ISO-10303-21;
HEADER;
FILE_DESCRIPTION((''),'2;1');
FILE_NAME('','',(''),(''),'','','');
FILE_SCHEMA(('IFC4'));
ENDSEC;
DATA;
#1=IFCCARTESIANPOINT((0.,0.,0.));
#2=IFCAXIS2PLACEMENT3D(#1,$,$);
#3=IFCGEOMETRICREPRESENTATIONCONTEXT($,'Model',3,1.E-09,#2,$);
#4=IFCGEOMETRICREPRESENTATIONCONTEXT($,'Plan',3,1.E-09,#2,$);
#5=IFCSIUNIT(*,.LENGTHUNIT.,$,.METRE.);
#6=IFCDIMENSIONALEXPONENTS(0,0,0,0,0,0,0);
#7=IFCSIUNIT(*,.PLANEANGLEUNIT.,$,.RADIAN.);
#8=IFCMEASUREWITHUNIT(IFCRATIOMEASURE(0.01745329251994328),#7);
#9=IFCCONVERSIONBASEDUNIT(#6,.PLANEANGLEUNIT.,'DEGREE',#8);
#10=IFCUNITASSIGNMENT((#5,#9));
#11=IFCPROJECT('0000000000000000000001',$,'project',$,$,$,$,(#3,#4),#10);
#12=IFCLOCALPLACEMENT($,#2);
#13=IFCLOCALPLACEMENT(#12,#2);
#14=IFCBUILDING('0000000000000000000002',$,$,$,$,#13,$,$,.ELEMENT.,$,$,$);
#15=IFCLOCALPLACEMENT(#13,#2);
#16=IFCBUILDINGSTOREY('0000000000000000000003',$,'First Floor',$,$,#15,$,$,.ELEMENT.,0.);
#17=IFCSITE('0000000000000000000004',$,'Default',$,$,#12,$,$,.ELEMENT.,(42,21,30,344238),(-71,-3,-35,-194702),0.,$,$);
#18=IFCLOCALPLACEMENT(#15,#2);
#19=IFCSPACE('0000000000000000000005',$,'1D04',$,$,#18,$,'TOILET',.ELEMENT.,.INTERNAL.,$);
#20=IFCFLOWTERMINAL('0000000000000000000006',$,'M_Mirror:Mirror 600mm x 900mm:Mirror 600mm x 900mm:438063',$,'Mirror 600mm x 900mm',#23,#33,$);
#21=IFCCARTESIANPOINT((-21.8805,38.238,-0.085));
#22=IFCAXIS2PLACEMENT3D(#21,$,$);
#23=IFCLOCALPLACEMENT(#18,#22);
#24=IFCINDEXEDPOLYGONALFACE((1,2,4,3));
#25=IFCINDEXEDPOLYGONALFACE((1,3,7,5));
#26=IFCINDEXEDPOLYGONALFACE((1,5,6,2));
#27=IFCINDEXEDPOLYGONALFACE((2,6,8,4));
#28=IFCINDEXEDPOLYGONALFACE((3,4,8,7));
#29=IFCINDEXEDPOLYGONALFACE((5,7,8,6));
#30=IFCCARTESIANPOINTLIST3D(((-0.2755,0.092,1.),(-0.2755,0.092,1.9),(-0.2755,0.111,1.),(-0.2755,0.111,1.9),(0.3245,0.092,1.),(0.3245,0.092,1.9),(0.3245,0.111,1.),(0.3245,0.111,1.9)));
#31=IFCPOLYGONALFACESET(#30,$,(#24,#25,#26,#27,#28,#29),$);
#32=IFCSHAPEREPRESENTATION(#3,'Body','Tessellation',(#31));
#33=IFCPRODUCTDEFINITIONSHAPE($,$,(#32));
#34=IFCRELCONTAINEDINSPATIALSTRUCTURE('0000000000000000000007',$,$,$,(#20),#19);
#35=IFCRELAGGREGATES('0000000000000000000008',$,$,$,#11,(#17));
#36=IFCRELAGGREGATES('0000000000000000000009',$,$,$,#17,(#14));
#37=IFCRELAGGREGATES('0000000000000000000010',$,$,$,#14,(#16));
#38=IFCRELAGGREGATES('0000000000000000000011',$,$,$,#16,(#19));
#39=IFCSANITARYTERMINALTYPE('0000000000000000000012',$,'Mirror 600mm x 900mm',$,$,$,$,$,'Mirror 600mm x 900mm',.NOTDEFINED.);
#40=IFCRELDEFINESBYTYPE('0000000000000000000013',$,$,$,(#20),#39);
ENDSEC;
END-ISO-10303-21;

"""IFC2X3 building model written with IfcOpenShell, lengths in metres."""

from ifc_helpers import new_model, entity, si_unit, converted_unit, frame, origin, origin_2d_with_axis, place, context, project, spatial, rectangle, extrude, source, transform, mapped, type_object, type_shapes, element, save


model = new_model("IFC2X3")

# Units and contexts
model_context = context("Model", 3, precision=1e-09, world=origin())
plan_context = context("Plan", 3, precision=1e-09, world=origin())
ifc_project = project(units=[si_unit("LENGTHUNIT", "METRE"), converted_unit("PLANEANGLEUNIT", "DEGREE", entity("IfcRatioMeasure", 0.01745329251994328), si_unit("PLANEANGLEUNIT", "RADIAN"), dimensions=[0, 0, 0, 0, 0, 0, 0])], contexts=[model_context, plan_context])

# Site, building, storey
site_placement = place(None, origin())
site = spatial("IfcSite", under=ifc_project, at=site_placement, Name="Default", CompositionType="ELEMENT", RefLatitude=(42, 21, 30, 344238), RefLongitude=(-71, -3, -35, -194702), RefElevation=0.0)
building_placement = place(site_placement, origin())
building = spatial("IfcBuilding", under=site, at=building_placement, CompositionType="ELEMENT")
storey_placement = place(building_placement, origin())
storey = spatial("IfcBuildingStorey", under=building, at=storey_placement, Name="First Floor", CompositionType="ELEMENT", Elevation=0.0)

# Shared definitions
space_1_placement = place(storey_placement, origin())
space_1 = spatial("IfcSpace", under=storey, at=space_1_placement, Name="1D04", LongName="TOILET", CompositionType="ELEMENT", InteriorOrExteriorSpace="INTERNAL")

# Flow terminal
sanitary_terminal_type = type_object("IfcSanitaryTerminalType", Name="Mirror 600mm x 900mm", ElementType="Mirror 600mm x 900mm", PredefinedType="NOTDEFINED")
shared_shape_1 = source(origin(), model_context, "Body", "SweptSolid", [
    extrude(rectangle(XDim=0.0191, YDim=0.6, at=origin_2d_with_axis()), frame((0.0245, 0.1015, 1.0), z_axis=(0.0, 0.0, 1.0), x_axis=(0.0, -1.0, 0.0)), (0.0, 0.0, 1.0), 0.9),
])
type_shapes(sanitary_terminal_type, [shared_shape_1])
flow_terminal_placement = place(space_1_placement, frame((-21.8805, 38.238, -0.085)))
element("IfcFlowTerminal", 1, at=flow_terminal_placement, inside=space_1, type_object=sanitary_terminal_type, Name="M_Mirror:Mirror 600mm x 900mm:Mirror 600mm x 900mm:438063", ObjectType="Mirror 600mm x 900mm", context=model_context, shape_type="MappedRepresentation", body=[
    mapped(shared_shape_1, transform((0.0, 0.0, 0.0), scale=1.0)),
])

save(model, "model.ifc")
